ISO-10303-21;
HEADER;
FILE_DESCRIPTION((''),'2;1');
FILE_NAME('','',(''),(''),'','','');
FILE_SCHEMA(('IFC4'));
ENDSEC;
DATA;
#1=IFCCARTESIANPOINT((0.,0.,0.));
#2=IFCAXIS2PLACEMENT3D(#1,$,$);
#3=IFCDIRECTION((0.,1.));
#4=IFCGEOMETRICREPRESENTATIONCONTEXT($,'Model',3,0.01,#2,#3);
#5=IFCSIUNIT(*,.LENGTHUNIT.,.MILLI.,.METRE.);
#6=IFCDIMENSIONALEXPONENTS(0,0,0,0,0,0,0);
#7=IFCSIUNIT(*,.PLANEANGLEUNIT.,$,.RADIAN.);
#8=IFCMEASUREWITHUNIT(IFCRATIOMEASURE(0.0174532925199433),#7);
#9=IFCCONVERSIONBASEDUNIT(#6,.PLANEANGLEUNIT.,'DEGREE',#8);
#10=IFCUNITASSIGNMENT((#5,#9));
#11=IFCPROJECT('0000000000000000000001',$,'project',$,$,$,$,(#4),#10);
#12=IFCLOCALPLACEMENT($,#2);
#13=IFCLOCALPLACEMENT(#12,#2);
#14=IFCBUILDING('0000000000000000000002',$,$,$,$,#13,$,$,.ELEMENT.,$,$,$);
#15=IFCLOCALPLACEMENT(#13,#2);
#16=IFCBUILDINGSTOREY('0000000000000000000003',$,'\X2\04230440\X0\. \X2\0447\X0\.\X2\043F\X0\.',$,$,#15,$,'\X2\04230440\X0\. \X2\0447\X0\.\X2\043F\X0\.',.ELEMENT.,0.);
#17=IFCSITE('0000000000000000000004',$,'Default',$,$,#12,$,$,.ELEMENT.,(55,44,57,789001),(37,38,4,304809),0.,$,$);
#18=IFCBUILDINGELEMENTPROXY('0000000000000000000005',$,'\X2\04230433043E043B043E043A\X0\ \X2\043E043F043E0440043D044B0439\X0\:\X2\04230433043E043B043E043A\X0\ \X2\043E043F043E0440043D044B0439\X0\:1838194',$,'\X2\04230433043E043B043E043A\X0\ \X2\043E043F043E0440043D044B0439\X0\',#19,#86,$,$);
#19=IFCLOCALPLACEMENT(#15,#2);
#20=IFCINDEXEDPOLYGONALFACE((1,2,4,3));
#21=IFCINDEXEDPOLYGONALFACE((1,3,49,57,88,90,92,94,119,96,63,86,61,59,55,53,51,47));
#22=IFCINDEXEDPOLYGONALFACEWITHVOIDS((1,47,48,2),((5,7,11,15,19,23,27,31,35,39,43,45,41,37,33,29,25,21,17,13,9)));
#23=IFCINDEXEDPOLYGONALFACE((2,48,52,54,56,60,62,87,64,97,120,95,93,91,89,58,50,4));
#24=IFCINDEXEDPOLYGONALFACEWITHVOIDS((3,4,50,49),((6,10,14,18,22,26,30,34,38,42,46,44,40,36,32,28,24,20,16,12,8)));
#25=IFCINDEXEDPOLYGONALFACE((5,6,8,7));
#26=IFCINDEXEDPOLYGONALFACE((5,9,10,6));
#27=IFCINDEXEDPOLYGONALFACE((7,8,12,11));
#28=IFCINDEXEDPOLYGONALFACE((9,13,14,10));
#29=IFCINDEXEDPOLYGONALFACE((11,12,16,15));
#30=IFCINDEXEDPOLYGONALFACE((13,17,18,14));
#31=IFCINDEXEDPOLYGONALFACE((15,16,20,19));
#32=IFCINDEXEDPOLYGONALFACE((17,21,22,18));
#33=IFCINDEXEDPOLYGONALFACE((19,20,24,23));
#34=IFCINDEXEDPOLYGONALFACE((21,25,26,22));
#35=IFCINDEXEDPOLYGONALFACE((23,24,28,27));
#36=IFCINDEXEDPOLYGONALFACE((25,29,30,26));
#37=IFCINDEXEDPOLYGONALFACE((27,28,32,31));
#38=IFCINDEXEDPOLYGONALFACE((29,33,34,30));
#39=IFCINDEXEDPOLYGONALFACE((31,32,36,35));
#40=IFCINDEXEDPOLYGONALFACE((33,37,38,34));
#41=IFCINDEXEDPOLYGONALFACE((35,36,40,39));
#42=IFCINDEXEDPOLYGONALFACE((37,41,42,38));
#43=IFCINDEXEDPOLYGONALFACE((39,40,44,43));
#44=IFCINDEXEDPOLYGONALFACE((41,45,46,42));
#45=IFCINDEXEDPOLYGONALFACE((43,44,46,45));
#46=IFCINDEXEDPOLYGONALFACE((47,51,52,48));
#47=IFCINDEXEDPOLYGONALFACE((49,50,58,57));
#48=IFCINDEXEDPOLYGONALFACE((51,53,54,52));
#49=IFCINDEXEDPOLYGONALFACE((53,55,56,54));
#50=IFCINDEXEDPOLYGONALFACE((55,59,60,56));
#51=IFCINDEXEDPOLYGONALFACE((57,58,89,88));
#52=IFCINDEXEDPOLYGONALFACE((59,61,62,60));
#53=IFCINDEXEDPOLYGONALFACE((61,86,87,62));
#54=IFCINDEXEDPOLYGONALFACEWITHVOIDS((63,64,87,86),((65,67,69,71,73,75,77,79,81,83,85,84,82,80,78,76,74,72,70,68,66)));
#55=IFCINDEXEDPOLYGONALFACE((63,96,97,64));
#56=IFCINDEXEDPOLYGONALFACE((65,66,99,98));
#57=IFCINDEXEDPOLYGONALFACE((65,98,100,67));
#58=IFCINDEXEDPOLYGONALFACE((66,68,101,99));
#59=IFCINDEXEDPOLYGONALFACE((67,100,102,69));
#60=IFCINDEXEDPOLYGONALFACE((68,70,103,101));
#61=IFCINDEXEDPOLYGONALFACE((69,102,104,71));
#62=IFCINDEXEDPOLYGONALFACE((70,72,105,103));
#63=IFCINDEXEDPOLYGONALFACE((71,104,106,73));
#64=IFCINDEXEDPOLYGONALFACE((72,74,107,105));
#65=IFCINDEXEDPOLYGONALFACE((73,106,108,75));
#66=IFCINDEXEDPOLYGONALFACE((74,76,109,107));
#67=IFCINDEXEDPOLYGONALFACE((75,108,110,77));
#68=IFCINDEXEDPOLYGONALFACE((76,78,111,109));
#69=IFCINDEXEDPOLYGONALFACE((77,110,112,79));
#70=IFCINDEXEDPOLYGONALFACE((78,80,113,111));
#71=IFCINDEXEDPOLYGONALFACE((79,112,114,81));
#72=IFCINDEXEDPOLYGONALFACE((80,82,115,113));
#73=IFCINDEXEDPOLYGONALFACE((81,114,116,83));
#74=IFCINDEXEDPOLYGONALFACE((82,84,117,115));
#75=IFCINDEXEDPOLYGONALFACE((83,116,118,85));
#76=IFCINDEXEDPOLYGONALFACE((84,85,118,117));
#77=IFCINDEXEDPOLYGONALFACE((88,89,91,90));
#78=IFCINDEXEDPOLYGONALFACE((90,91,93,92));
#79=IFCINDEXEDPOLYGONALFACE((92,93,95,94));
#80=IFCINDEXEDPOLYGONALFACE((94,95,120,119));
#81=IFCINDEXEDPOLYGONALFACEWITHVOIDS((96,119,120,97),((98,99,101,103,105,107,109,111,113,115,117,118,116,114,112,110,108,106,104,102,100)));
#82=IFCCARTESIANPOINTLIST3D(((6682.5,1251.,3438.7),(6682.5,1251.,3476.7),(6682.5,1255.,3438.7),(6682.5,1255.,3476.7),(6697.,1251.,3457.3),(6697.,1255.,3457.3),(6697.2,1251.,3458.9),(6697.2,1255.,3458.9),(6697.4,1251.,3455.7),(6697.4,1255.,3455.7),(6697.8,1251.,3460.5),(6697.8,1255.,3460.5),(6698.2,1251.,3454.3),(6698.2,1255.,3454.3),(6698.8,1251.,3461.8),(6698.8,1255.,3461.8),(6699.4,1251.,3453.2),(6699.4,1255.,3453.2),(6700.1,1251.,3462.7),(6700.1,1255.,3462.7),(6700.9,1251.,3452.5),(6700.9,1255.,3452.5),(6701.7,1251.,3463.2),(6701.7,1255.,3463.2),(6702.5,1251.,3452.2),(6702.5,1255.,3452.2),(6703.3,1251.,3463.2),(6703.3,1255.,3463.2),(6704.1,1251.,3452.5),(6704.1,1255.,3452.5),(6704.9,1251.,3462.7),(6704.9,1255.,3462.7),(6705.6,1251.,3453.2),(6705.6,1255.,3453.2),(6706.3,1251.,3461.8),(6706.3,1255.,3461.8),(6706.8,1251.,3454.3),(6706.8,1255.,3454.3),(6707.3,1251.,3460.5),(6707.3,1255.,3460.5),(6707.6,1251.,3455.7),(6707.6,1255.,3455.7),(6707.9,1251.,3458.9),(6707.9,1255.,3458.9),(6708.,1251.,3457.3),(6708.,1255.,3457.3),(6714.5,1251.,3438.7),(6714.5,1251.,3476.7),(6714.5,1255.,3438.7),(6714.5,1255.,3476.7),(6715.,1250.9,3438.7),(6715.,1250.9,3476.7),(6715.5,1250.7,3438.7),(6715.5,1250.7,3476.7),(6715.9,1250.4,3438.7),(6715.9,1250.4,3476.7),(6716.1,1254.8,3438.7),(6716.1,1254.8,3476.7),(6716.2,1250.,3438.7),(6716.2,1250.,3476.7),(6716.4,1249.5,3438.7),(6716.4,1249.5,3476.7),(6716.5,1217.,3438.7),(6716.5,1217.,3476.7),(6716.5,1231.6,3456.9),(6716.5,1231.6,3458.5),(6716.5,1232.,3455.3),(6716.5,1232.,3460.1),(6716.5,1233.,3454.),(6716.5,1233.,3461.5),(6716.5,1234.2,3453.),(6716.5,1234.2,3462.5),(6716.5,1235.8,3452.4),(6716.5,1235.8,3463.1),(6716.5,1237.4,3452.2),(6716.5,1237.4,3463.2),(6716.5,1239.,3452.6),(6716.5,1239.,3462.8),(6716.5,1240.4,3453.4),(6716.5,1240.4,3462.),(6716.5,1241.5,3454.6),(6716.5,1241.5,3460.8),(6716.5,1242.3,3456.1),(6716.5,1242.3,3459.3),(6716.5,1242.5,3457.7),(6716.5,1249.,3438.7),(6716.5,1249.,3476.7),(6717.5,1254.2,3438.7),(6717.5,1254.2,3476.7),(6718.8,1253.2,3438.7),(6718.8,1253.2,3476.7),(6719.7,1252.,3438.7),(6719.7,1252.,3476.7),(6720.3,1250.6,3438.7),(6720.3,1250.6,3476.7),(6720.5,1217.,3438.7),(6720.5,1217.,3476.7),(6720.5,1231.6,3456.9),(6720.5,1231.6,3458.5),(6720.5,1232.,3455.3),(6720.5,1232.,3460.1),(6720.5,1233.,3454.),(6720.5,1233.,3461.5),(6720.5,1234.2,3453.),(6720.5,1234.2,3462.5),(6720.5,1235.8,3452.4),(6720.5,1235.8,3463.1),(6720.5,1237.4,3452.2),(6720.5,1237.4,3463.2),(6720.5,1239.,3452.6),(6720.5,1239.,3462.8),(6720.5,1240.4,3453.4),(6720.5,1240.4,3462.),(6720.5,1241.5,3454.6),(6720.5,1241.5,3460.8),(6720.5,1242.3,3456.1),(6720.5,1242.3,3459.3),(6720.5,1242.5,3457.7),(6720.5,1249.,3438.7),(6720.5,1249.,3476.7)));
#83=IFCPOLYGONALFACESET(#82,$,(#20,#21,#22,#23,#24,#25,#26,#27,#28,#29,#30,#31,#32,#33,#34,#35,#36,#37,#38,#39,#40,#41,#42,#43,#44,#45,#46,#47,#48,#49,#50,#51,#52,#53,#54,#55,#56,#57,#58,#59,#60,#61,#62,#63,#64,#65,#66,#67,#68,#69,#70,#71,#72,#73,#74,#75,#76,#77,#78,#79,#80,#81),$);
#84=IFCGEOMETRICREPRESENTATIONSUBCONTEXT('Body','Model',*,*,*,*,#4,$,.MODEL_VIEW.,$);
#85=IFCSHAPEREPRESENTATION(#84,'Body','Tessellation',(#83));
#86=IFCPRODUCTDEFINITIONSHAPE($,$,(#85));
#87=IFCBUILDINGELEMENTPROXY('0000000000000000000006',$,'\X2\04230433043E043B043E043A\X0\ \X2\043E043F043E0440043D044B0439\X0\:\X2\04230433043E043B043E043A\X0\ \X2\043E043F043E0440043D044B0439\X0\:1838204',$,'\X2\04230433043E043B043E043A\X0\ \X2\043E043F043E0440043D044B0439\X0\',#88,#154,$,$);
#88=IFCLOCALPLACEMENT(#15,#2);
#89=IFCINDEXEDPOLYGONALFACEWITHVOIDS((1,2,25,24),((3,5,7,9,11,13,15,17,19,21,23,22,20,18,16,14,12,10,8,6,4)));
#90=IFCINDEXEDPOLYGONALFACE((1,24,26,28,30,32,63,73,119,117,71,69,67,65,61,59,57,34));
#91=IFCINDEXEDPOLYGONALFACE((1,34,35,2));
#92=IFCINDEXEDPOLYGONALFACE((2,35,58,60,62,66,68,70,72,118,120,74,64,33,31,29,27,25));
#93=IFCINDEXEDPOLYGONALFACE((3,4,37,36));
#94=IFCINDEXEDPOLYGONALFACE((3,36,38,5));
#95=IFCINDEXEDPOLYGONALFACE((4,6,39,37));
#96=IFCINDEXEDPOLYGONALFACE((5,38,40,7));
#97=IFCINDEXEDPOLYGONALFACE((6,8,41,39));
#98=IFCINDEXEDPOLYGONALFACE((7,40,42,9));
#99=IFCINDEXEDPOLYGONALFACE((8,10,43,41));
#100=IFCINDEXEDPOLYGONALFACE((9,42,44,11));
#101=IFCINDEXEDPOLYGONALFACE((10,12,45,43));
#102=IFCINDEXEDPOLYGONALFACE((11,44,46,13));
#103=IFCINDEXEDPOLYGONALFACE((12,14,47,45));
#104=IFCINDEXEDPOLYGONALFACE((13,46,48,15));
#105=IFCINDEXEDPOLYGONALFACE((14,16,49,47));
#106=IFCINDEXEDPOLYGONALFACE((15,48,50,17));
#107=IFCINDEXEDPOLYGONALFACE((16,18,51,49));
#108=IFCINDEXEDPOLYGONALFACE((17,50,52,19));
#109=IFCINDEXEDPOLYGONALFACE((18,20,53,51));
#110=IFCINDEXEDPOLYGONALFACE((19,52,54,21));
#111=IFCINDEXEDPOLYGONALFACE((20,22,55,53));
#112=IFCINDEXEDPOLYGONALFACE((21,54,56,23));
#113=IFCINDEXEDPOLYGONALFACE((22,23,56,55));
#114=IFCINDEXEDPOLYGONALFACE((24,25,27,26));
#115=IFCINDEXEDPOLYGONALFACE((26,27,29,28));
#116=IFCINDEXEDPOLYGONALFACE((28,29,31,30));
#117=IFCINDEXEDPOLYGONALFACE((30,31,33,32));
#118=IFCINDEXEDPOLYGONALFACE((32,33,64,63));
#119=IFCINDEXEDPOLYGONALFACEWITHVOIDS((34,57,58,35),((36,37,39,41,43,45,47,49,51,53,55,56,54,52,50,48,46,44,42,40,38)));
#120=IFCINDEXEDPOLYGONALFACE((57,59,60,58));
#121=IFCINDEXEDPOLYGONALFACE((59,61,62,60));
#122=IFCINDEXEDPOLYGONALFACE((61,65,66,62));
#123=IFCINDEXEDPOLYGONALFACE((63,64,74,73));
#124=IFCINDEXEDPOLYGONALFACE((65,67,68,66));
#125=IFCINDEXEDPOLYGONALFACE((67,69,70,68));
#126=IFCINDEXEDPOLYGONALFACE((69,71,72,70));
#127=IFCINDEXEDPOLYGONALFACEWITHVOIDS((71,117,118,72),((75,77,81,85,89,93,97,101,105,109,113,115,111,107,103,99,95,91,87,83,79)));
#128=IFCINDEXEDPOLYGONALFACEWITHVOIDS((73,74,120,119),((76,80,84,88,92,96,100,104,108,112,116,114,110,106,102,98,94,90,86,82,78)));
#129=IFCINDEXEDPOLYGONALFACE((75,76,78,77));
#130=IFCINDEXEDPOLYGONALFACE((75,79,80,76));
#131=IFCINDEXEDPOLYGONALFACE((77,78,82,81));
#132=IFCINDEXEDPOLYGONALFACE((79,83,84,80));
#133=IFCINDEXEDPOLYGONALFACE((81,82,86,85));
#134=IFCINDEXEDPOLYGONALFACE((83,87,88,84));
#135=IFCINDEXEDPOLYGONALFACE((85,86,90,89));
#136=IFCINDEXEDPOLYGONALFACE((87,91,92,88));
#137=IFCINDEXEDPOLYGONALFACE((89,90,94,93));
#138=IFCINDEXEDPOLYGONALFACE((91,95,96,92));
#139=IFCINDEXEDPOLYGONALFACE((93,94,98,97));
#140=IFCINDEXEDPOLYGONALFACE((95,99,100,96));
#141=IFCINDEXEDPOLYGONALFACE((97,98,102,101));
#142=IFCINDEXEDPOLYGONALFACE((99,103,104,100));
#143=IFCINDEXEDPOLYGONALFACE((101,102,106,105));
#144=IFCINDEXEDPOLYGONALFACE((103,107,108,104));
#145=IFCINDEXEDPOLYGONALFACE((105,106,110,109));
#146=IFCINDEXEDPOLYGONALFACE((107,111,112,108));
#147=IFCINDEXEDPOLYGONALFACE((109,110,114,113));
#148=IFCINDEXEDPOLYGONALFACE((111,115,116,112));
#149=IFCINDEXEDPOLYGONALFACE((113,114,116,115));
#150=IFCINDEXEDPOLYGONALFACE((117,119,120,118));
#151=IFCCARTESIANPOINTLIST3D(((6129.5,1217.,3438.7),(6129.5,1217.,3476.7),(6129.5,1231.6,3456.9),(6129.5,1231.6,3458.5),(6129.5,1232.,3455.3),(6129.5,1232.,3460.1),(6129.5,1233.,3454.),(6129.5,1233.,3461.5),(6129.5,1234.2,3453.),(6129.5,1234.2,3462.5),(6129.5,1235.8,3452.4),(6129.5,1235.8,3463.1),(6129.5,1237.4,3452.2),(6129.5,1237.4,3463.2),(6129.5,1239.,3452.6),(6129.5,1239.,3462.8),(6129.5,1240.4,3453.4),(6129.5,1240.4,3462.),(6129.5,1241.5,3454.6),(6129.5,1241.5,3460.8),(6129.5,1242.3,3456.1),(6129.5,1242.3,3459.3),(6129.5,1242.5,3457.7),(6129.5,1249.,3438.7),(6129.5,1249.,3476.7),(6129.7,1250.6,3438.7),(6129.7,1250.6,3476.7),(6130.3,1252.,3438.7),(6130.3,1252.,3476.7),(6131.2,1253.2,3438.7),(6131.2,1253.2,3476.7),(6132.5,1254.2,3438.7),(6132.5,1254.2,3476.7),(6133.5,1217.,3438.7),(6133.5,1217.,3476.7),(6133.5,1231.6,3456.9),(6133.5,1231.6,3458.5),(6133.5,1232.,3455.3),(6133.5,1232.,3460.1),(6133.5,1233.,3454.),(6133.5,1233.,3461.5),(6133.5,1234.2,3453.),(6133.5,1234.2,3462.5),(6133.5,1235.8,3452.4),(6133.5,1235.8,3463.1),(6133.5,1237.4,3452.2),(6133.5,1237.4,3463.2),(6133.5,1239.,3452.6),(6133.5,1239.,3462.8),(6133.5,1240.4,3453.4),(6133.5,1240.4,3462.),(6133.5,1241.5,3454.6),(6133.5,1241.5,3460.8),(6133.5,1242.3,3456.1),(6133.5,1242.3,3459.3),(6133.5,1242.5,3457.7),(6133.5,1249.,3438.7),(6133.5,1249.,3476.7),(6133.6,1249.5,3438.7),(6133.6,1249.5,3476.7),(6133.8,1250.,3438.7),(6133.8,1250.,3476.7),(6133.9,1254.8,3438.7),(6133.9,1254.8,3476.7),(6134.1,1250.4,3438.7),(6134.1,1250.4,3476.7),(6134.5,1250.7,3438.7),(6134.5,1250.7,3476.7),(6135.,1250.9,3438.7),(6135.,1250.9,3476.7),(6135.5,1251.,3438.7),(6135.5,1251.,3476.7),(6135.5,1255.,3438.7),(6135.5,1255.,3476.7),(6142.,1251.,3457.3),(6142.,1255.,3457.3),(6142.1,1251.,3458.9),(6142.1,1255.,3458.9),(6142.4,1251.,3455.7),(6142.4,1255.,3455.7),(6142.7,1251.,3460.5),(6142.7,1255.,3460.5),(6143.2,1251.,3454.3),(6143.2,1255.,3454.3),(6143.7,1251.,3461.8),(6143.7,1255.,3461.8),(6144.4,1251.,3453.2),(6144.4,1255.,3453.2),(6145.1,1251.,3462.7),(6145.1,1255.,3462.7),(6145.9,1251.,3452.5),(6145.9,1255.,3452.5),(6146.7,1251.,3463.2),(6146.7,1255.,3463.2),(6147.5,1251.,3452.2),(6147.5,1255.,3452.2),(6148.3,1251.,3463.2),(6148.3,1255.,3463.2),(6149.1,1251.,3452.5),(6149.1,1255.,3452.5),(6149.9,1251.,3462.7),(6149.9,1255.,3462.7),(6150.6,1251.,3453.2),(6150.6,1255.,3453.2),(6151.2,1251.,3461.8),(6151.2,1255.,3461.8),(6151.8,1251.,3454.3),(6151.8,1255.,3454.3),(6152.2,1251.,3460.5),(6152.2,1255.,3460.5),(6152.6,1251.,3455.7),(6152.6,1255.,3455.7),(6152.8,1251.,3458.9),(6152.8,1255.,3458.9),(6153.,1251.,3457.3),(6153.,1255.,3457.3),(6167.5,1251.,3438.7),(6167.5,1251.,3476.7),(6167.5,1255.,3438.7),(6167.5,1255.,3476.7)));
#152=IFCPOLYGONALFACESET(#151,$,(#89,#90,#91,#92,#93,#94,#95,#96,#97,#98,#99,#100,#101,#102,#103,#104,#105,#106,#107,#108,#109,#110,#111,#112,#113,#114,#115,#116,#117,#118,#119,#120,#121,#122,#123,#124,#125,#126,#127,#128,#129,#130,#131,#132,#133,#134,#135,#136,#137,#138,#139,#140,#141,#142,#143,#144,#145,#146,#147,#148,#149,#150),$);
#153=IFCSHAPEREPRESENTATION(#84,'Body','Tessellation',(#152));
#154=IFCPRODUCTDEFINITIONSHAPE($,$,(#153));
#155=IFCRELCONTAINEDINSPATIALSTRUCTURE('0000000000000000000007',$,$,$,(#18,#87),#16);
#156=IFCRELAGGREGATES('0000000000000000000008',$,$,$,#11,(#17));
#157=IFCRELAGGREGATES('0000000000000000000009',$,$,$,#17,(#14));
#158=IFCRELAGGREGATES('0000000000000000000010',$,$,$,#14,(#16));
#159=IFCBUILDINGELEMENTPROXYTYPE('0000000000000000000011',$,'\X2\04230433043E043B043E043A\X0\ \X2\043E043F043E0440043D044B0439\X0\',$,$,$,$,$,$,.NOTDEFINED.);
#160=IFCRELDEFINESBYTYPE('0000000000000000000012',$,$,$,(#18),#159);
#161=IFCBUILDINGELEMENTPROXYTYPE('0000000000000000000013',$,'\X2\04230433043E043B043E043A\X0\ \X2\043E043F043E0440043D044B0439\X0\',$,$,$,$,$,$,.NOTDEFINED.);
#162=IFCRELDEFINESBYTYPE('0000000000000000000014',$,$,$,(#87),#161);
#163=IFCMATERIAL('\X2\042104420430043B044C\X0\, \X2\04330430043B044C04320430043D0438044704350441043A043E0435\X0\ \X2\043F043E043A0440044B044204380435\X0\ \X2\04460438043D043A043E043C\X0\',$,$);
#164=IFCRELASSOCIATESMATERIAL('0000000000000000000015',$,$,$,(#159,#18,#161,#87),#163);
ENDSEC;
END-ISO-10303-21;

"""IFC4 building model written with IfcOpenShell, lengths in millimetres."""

from ifc_helpers import new_model, entity, si_unit, converted_unit, direction, frame, frame_2d, origin, place, context, subcontext, project, spatial, polyline, circle_curve, parameter, trimmed, segment, composite_curve, circle, outline, extrude, source, transform, mapped, material, type_object, type_shapes, element, save


model = new_model("IFC4")

# Units and contexts
model_context = context("Model", 3, precision=0.01, world=origin(), true_north=direction((0.0, 1.0)))
body_context = subcontext(model_context, "Body", "Model", "MODEL_VIEW")
ifc_project = project(units=[si_unit("LENGTHUNIT", "METRE", prefix="MILLI"), converted_unit("PLANEANGLEUNIT", "DEGREE", entity("IfcRatioMeasure", 0.0174532925199433), si_unit("PLANEANGLEUNIT", "RADIAN"), dimensions=[0, 0, 0, 0, 0, 0, 0])], contexts=[model_context])

# Site, building, storey
site_placement = place(None, origin())
site = spatial("IfcSite", under=ifc_project, at=site_placement, Name="Default", CompositionType="ELEMENT", RefLatitude=(55, 44, 57, 789001), RefLongitude=(37, 38, 4, 304809), RefElevation=0.0)
building_placement = place(site_placement, origin())
building = spatial("IfcBuilding", under=site, at=building_placement, CompositionType="ELEMENT")
storey_placement = place(building_placement, origin())
storey = spatial("IfcBuildingStorey", under=building, at=storey_placement, Name="Ур. ч.п.", LongName="Ур. ч.п.", CompositionType="ELEMENT", Elevation=0.0)

# Building element proxies, openings
ifc_material = material(Name="Сталь, гальваническое покрытие цинком")
building_element_proxy_type_1 = type_object("IfcBuildingElementProxyType", Name="Уголок опорный", material=ifc_material)
shared_shape_1 = source(origin(), body_context, "Body", "SweptSolid", [
    extrude(outline(composite_curve([segment(polyline([(-6.0, -12.0), (26.0, -12.0)]), True, "CONTINUOUS"), segment(polyline([(26.0, -12.0), (26.0, -8.0)]), True, "CONTINUOUS"), segment(polyline([(26.0, -8.0), (-6.0, -8.0)]), True, "CONTINUOUS"), segment(trimmed(circle_curve(frame_2d((-6.0, -6.0), x_axis=(0.0, -1.0)), 2.0), [parameter(270.0)], [parameter(0.0)], True, "PARAMETER"), False, "CONTINUOUS"), segment(polyline([(-8.0, -6.0), (-8.0, 26.0)]), True, "CONTINUOUS"), segment(polyline([(-8.0, 26.0), (-12.0, 26.0)]), True, "CONTINUOUS"), segment(polyline([(-12.0, 26.0), (-12.0, -6.0)]), True, "CONTINUOUS"), segment(trimmed(circle_curve(frame_2d((-6.0, -6.0), x_axis=(0.0, -1.0)), 6.0), [parameter(270.0)], [parameter(360.0)], True, "PARAMETER"), True, "CONTINUOUS")], self_intersect=False)), frame((12.0, -19.0, 12.0), z_axis=(0.0, 1.0, 0.0), x_axis=(0.0, 0.0, 1.0)), (0.0, 0.0, 1.0), 38.0),
])
type_shapes(building_element_proxy_type_1, [shared_shape_1])
proxy_1_placement = place(storey_placement, frame((6720.5, 1255.0, 3457.7), z_axis=(0.0, -1.0, 0.0), x_axis=(-1.0, 0.0, 0.0)))
proxy_1 = element("IfcBuildingElementProxy", 1, at=proxy_1_placement, inside=storey, type_object=building_element_proxy_type_1, material=ifc_material, Name="Уголок опорный:Уголок опорный:1838194", ObjectType="Уголок опорный", context=body_context, shape_type="MappedRepresentation", body=[
    mapped(shared_shape_1, transform((0.0, 0.0, 0.0), scale=1.0)),
])
opening_1_placement = place(storey_placement, frame((6720.5, 1255.0, 3457.7)))
element("IfcOpeningElement", 2, at=opening_1_placement, cuts=proxy_1, ObjectType="Opening", PredefinedType="OPENING", context=body_context, shape_type="SweptSolid", body=[
    extrude(circle(Radius=5.5, at=frame_2d((0.0, 0.0), x_axis=(1.0, 0.0))), frame((-4.0, -18.0, 0.0), z_axis=(1.0, 0.0, 0.0), x_axis=(0.0, 1.0, 0.0)), (0.0, 0.0, 1.0), 4.0),
])
opening_2_placement = place(storey_placement, frame((6720.5, 1255.0, 3457.7)))
element("IfcOpeningElement", 3, at=opening_2_placement, cuts=proxy_1, ObjectType="Opening", PredefinedType="OPENING", context=body_context, shape_type="SweptSolid", body=[
    extrude(circle(Radius=5.5, at=frame_2d((0.0, 0.0), x_axis=(1.0, 0.0))), frame((-18.0, 0.0, 0.0), z_axis=(0.0, -1.0, 0.0), x_axis=(0.0, 0.0, -1.0)), (0.0, 0.0, 1.0), 4.0),
])
building_element_proxy_type_2 = type_object("IfcBuildingElementProxyType", Name="Уголок опорный", material=ifc_material)
shared_shape_2 = source(origin(), body_context, "Body", "SweptSolid", [
    extrude(outline(composite_curve([segment(polyline([(-6.0, -12.0), (26.0, -12.0)]), True, "CONTINUOUS"), segment(polyline([(26.0, -12.0), (26.0, -8.0)]), True, "CONTINUOUS"), segment(polyline([(26.0, -8.0), (-6.0, -8.0)]), True, "CONTINUOUS"), segment(trimmed(circle_curve(frame_2d((-6.0, -6.0), x_axis=(0.0, -1.0)), 2.0), [parameter(270.0)], [parameter(0.0)], True, "PARAMETER"), False, "CONTINUOUS"), segment(polyline([(-8.0, -6.0), (-8.0, 26.0)]), True, "CONTINUOUS"), segment(polyline([(-8.0, 26.0), (-12.0, 26.0)]), True, "CONTINUOUS"), segment(polyline([(-12.0, 26.0), (-12.0, -6.0)]), True, "CONTINUOUS"), segment(trimmed(circle_curve(frame_2d((-6.0, -6.0), x_axis=(0.0, -1.0)), 6.0), [parameter(270.0)], [parameter(360.0)], True, "PARAMETER"), True, "CONTINUOUS")], self_intersect=False)), frame((12.0, -19.0, 12.0), z_axis=(0.0, 1.0, 0.0), x_axis=(0.0, 0.0, 1.0)), (0.0, 0.0, 1.0), 38.0),
])
type_shapes(building_element_proxy_type_2, [shared_shape_2])
proxy_2_placement = place(storey_placement, frame((6129.5, 1255.0, 3457.7), z_axis=(0.0, -1.0, 0.0), x_axis=(1.0, 0.0, 0.0)))
proxy_2 = element("IfcBuildingElementProxy", 4, at=proxy_2_placement, inside=storey, type_object=building_element_proxy_type_2, material=ifc_material, Name="Уголок опорный:Уголок опорный:1838204", ObjectType="Уголок опорный", context=body_context, shape_type="MappedRepresentation", body=[
    mapped(shared_shape_2, transform((0.0, 0.0, 0.0), scale=1.0)),
])
opening_3_placement = place(storey_placement, frame((6129.5, 1255.0, 3457.7), z_axis=(0.0, 0.0, -1.0), x_axis=(1.0, 0.0, 0.0)))
element("IfcOpeningElement", 5, at=opening_3_placement, cuts=proxy_2, ObjectType="Opening", PredefinedType="OPENING", context=body_context, shape_type="SweptSolid", body=[
    extrude(circle(Radius=5.5, at=frame_2d((0.0, 0.0), x_axis=(1.0, 0.0))), frame((0.0, 18.0, 0.0), z_axis=(1.0, 0.0, 0.0), x_axis=(0.0, -1.0, 0.0)), (0.0, 0.0, 1.0), 4.0),
])
opening_4_placement = place(storey_placement, frame((6129.5, 1255.0, 3457.7), z_axis=(0.0, 0.0, -1.0), x_axis=(1.0, 0.0, 0.0)))
element("IfcOpeningElement", 6, at=opening_4_placement, cuts=proxy_2, ObjectType="Opening", PredefinedType="OPENING", context=body_context, shape_type="SweptSolid", body=[
    extrude(circle(Radius=5.5, at=frame_2d((0.0, 0.0), x_axis=(1.0, 0.0))), frame((18.0, 0.0, 0.0), z_axis=(0.0, 1.0, 0.0), x_axis=(0.0, 0.0, 1.0)), (0.0, 0.0, 1.0), 4.0),
])

save(model, "model.ifc")
